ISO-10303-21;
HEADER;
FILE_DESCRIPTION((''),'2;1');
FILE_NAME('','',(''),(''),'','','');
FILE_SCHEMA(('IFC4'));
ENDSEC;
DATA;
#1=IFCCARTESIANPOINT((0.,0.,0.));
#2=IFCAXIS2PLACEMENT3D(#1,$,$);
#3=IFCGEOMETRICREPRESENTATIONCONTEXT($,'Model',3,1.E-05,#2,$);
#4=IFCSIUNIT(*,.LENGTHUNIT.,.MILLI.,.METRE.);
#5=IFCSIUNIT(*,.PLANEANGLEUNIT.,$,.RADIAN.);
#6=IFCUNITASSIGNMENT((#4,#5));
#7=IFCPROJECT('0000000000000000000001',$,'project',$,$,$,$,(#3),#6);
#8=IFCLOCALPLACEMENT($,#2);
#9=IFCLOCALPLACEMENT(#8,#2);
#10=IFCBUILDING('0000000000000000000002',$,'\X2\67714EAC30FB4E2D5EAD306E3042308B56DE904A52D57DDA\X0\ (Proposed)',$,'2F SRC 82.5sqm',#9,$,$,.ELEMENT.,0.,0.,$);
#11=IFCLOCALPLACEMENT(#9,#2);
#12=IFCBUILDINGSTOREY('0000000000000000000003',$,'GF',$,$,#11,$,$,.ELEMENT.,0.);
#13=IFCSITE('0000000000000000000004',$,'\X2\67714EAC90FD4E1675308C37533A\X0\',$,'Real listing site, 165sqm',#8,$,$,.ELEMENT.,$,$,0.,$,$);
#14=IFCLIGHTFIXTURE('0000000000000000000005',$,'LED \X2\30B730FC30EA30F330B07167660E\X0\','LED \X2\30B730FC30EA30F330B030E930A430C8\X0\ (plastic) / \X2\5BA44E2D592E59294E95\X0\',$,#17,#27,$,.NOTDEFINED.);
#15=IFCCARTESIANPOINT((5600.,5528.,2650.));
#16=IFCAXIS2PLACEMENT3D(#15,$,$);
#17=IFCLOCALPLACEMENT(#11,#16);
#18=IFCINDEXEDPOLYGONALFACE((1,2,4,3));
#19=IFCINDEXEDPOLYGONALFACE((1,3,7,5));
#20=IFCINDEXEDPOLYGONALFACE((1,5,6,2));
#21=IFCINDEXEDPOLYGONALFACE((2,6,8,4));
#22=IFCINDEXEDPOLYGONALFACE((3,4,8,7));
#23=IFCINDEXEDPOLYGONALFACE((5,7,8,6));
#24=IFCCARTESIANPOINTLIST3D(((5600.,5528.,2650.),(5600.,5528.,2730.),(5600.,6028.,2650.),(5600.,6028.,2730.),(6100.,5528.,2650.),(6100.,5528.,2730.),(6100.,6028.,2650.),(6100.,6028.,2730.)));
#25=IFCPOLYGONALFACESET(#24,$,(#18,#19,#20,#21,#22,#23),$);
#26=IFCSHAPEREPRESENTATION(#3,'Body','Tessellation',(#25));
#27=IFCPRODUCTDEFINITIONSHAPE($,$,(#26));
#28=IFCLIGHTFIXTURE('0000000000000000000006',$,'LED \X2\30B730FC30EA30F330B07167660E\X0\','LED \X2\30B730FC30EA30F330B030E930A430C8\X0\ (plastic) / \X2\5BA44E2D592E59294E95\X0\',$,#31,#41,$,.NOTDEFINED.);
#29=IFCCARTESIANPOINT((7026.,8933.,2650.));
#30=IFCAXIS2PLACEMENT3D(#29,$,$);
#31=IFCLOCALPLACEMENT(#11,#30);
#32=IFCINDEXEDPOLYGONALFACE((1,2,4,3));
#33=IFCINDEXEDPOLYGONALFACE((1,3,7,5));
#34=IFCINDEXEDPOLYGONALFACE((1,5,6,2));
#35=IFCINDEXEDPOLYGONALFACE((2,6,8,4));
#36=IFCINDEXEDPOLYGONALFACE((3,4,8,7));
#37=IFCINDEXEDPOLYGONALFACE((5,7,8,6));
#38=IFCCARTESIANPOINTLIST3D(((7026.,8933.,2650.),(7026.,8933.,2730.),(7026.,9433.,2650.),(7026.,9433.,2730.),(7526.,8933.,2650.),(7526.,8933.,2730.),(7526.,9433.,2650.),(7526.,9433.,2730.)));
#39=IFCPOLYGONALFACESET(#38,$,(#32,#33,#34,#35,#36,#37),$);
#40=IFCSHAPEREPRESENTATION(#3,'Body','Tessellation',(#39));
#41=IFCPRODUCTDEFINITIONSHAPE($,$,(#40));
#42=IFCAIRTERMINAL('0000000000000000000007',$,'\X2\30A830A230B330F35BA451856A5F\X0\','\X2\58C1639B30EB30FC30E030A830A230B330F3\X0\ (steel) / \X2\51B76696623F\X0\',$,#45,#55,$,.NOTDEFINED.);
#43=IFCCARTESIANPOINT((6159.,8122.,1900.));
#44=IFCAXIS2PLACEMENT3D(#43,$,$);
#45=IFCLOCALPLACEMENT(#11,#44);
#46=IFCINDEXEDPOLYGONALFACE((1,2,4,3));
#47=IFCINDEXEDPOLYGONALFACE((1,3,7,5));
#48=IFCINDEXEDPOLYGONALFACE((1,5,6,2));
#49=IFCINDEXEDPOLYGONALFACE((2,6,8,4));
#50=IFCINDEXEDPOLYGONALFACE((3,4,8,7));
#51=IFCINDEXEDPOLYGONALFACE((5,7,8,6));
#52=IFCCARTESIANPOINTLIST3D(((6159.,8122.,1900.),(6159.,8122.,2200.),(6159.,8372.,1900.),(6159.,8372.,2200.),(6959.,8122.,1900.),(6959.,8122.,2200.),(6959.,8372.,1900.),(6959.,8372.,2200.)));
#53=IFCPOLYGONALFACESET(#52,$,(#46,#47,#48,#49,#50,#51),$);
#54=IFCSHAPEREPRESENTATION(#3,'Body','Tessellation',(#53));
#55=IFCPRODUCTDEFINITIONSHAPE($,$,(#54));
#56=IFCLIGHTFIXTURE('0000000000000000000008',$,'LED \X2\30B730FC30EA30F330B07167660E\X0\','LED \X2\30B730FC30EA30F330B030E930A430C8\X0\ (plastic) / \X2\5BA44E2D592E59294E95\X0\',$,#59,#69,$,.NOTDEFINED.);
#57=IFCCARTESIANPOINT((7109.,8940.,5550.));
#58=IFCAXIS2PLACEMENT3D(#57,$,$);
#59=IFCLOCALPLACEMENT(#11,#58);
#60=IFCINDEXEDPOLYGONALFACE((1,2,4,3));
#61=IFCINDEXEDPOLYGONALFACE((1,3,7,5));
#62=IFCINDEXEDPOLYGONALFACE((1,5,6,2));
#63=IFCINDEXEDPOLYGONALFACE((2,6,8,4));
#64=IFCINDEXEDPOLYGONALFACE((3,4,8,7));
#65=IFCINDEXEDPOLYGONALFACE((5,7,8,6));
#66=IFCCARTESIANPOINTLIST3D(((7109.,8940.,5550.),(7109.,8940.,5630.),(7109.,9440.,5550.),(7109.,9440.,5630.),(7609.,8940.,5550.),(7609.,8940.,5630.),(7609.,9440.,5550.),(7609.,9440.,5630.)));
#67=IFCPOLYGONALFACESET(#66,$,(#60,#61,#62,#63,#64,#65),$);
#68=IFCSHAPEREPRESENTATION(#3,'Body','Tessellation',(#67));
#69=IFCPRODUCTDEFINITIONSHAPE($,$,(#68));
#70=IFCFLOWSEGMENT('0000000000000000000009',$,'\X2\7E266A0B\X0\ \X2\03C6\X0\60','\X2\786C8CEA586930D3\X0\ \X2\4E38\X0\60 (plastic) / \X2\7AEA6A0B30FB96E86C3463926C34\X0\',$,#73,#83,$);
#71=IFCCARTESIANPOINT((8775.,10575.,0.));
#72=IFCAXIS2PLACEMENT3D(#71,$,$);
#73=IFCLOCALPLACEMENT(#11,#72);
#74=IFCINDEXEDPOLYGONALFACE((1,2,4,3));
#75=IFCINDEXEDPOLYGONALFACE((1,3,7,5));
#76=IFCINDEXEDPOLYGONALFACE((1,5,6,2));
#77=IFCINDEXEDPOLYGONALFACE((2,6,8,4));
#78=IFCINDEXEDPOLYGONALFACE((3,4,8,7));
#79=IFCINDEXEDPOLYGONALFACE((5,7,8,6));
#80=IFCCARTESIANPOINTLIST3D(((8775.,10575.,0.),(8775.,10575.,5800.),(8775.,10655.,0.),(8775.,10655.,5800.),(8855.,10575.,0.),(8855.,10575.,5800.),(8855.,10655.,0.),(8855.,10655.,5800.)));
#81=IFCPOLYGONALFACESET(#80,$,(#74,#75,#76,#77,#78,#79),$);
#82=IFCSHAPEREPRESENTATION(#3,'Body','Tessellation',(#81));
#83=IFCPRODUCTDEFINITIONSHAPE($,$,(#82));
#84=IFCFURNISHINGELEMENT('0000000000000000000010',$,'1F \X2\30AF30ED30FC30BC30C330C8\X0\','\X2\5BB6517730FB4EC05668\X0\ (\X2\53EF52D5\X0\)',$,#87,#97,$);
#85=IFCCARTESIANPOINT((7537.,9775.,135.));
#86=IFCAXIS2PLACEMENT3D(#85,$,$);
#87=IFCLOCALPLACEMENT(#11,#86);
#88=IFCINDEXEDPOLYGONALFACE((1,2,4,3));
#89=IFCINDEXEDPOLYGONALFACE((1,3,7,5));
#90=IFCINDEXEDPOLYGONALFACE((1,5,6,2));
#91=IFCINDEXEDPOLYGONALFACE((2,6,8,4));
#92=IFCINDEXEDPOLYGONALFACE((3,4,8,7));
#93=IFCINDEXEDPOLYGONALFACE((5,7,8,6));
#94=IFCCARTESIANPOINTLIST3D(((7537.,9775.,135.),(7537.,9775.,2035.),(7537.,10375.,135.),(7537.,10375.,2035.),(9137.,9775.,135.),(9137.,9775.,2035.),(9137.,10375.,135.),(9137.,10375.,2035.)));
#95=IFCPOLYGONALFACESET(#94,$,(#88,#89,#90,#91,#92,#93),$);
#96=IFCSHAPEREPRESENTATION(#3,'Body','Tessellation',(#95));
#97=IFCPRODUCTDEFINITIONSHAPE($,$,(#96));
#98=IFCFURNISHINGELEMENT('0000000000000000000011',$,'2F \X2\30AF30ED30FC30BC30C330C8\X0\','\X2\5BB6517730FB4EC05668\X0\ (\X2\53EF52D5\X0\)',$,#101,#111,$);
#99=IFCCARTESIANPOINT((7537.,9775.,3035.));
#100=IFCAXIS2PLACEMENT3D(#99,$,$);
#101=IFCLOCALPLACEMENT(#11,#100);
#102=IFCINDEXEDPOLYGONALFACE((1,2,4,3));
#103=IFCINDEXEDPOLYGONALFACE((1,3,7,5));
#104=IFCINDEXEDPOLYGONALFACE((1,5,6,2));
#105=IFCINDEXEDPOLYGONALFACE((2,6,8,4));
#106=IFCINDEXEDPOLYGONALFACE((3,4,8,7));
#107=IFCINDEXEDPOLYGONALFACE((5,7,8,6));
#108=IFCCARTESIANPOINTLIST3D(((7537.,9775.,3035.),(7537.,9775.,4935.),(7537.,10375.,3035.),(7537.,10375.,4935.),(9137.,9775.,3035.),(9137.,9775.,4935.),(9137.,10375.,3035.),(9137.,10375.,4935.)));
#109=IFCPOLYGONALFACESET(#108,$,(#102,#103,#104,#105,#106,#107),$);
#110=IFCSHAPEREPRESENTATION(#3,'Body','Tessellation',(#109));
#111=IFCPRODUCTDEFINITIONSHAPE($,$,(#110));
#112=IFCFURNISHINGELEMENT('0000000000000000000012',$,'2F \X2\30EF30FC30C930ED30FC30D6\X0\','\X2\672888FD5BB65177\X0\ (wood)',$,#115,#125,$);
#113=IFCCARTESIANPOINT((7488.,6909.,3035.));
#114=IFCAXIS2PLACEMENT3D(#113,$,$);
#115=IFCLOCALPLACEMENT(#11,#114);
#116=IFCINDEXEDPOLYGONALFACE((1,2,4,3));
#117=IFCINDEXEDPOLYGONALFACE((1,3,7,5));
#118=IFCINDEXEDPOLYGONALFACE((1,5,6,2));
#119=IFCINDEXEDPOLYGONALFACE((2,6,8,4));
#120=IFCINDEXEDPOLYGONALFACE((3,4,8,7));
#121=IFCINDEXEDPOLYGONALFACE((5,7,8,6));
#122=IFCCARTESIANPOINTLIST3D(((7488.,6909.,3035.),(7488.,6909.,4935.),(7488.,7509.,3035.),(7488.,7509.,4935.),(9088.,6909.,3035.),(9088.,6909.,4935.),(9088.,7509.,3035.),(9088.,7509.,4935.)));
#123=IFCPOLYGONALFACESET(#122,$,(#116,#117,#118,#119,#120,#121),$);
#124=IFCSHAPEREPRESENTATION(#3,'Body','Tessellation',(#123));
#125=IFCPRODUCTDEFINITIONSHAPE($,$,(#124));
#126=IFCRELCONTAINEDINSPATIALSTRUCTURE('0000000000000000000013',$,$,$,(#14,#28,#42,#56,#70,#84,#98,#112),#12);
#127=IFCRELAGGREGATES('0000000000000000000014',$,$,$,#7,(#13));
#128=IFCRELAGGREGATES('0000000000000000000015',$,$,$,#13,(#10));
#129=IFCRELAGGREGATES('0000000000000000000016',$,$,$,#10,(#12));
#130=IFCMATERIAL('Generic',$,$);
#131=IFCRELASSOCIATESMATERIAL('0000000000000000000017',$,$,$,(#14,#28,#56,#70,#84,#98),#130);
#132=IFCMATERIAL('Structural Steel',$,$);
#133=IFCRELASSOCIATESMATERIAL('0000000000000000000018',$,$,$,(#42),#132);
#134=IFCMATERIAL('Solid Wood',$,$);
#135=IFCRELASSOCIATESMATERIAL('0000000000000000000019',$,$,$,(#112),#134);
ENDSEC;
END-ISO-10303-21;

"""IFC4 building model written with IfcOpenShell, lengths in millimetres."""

from ifc_helpers import new_model, si_unit, frame, frame_2d, origin, place, context, project, spatial, rectangle, extrude, material, element, save


model = new_model("IFC4")

# Units and contexts
model_context = context("Model", 3, precision=1e-05, world=origin())
ifc_project = project(units=[si_unit("LENGTHUNIT", "METRE", prefix="MILLI"), si_unit("PLANEANGLEUNIT", "RADIAN")], contexts=[model_context])

# Site, building, storey
site_placement = place(None, origin())
site = spatial("IfcSite", under=ifc_project, at=site_placement, Name="東京都世田谷区", ObjectType="Real listing site, 165sqm", CompositionType="ELEMENT", RefElevation=0.0)
building_placement = place(site_placement, origin())
building = spatial("IfcBuilding", under=site, at=building_placement, Name="東京・中庭のある回遊動線 (Proposed)", ObjectType="2F SRC 82.5sqm", CompositionType="ELEMENT", ElevationOfRefHeight=0.0, ElevationOfTerrain=0.0)
storey_placement = place(building_placement, origin())
storey = spatial("IfcBuildingStorey", under=building, at=storey_placement, Name="GF", CompositionType="ELEMENT", Elevation=0.0)

# Shared definitions
ifc_material_1 = material(Name="Solid Wood")

# Shared definitions
ifc_material_2 = material(Name="Structural Steel")

# Shared definitions
ifc_material_3 = material(Name="Generic")

# Light fixtures
light_fixture_1_placement = place(storey_placement, frame((5600.0, 5528.0, 2650.0)))
element("IfcLightFixture", 1, at=light_fixture_1_placement, inside=storey, material=ifc_material_3, Name="LED シーリング照明", Description="LED シーリングライト (plastic) / 室中央天井", PredefinedType="NOTDEFINED", context=model_context, shape_type="SweptSolid", body=[
    extrude(rectangle(XDim=500.0, YDim=500.0, at=frame_2d((250.0, 250.0))), frame((5600.0, 5528.0, 2650.0)), (0.0, 0.0, 1.0), 80.0),
])
light_fixture_2_placement = place(storey_placement, frame((7026.0, 8933.0, 2650.0)))
element("IfcLightFixture", 2, at=light_fixture_2_placement, inside=storey, material=ifc_material_3, Name="LED シーリング照明", Description="LED シーリングライト (plastic) / 室中央天井", PredefinedType="NOTDEFINED", context=model_context, shape_type="SweptSolid", body=[
    extrude(rectangle(XDim=500.0, YDim=500.0, at=frame_2d((250.0, 250.0))), frame((7026.0, 8933.0, 2650.0)), (0.0, 0.0, 1.0), 80.0),
])

# Air terminal
air_terminal_placement = place(storey_placement, frame((6159.0, 8122.0, 1900.0)))
element("IfcAirTerminal", 3, at=air_terminal_placement, inside=storey, material=ifc_material_2, Name="エアコン室内機", Description="壁掛ルームエアコン (steel) / 冷暖房", PredefinedType="NOTDEFINED", context=model_context, shape_type="SweptSolid", body=[
    extrude(rectangle(XDim=800.0, YDim=250.0, at=frame_2d((400.0, 125.0))), frame((6159.0, 8122.0, 1900.0)), (0.0, 0.0, 1.0), 300.0),
])

# Light fixture
light_fixture_3_placement = place(storey_placement, frame((7109.0, 8940.0, 5550.0)))
element("IfcLightFixture", 4, at=light_fixture_3_placement, inside=storey, material=ifc_material_3, Name="LED シーリング照明", Description="LED シーリングライト (plastic) / 室中央天井", PredefinedType="NOTDEFINED", context=model_context, shape_type="SweptSolid", body=[
    extrude(rectangle(XDim=500.0, YDim=500.0, at=frame_2d((250.0, 250.0))), frame((7109.0, 8940.0, 5550.0)), (0.0, 0.0, 1.0), 80.0),
])

# Flow segment
flow_segment_placement = place(storey_placement, frame((8775.0, 10575.0, 0.0)))
element("IfcFlowSegment", 5, at=flow_segment_placement, inside=storey, material=ifc_material_3, Name="縦樋 φ60", Description="硬質塩ビ 丸60 (plastic) / 竪樋・雨水排水", context=model_context, shape_type="SweptSolid", body=[
    extrude(rectangle(XDim=80.0, YDim=80.0, at=frame_2d((40.0, 40.0))), frame((8775.0, 10575.0, 0.0)), (0.0, 0.0, 1.0), 5800.0),
])

# Furnishing elements
furnishing_1_placement = place(storey_placement, frame((7537.0, 9775.0, 135.0)))
element("IfcFurnishingElement", 6, at=furnishing_1_placement, inside=storey, material=ifc_material_3, Name="1F クローゼット", Description="家具・什器 (可動)", context=model_context, shape_type="SweptSolid", body=[
    extrude(rectangle(XDim=1600.0, YDim=600.0, at=frame_2d((800.0, 300.0))), frame((7537.0, 9775.0, 135.0)), (0.0, 0.0, 1.0), 1900.0),
])
furnishing_2_placement = place(storey_placement, frame((7537.0, 9775.0, 3035.0)))
element("IfcFurnishingElement", 7, at=furnishing_2_placement, inside=storey, material=ifc_material_3, Name="2F クローゼット", Description="家具・什器 (可動)", context=model_context, shape_type="SweptSolid", body=[
    extrude(rectangle(XDim=1600.0, YDim=600.0, at=frame_2d((800.0, 300.0))), frame((7537.0, 9775.0, 3035.0)), (0.0, 0.0, 1.0), 1900.0),
])
furnishing_3_placement = place(storey_placement, frame((7488.0, 6909.0, 3035.0)))
element("IfcFurnishingElement", 8, at=furnishing_3_placement, inside=storey, material=ifc_material_1, Name="2F ワードローブ", Description="木製家具 (wood)", context=model_context, shape_type="SweptSolid", body=[
    extrude(rectangle(XDim=1600.0, YDim=600.0, at=frame_2d((800.0, 300.0))), frame((7488.0, 6909.0, 3035.0)), (0.0, 0.0, 1.0), 1900.0),
])

save(model, "model.ifc")
